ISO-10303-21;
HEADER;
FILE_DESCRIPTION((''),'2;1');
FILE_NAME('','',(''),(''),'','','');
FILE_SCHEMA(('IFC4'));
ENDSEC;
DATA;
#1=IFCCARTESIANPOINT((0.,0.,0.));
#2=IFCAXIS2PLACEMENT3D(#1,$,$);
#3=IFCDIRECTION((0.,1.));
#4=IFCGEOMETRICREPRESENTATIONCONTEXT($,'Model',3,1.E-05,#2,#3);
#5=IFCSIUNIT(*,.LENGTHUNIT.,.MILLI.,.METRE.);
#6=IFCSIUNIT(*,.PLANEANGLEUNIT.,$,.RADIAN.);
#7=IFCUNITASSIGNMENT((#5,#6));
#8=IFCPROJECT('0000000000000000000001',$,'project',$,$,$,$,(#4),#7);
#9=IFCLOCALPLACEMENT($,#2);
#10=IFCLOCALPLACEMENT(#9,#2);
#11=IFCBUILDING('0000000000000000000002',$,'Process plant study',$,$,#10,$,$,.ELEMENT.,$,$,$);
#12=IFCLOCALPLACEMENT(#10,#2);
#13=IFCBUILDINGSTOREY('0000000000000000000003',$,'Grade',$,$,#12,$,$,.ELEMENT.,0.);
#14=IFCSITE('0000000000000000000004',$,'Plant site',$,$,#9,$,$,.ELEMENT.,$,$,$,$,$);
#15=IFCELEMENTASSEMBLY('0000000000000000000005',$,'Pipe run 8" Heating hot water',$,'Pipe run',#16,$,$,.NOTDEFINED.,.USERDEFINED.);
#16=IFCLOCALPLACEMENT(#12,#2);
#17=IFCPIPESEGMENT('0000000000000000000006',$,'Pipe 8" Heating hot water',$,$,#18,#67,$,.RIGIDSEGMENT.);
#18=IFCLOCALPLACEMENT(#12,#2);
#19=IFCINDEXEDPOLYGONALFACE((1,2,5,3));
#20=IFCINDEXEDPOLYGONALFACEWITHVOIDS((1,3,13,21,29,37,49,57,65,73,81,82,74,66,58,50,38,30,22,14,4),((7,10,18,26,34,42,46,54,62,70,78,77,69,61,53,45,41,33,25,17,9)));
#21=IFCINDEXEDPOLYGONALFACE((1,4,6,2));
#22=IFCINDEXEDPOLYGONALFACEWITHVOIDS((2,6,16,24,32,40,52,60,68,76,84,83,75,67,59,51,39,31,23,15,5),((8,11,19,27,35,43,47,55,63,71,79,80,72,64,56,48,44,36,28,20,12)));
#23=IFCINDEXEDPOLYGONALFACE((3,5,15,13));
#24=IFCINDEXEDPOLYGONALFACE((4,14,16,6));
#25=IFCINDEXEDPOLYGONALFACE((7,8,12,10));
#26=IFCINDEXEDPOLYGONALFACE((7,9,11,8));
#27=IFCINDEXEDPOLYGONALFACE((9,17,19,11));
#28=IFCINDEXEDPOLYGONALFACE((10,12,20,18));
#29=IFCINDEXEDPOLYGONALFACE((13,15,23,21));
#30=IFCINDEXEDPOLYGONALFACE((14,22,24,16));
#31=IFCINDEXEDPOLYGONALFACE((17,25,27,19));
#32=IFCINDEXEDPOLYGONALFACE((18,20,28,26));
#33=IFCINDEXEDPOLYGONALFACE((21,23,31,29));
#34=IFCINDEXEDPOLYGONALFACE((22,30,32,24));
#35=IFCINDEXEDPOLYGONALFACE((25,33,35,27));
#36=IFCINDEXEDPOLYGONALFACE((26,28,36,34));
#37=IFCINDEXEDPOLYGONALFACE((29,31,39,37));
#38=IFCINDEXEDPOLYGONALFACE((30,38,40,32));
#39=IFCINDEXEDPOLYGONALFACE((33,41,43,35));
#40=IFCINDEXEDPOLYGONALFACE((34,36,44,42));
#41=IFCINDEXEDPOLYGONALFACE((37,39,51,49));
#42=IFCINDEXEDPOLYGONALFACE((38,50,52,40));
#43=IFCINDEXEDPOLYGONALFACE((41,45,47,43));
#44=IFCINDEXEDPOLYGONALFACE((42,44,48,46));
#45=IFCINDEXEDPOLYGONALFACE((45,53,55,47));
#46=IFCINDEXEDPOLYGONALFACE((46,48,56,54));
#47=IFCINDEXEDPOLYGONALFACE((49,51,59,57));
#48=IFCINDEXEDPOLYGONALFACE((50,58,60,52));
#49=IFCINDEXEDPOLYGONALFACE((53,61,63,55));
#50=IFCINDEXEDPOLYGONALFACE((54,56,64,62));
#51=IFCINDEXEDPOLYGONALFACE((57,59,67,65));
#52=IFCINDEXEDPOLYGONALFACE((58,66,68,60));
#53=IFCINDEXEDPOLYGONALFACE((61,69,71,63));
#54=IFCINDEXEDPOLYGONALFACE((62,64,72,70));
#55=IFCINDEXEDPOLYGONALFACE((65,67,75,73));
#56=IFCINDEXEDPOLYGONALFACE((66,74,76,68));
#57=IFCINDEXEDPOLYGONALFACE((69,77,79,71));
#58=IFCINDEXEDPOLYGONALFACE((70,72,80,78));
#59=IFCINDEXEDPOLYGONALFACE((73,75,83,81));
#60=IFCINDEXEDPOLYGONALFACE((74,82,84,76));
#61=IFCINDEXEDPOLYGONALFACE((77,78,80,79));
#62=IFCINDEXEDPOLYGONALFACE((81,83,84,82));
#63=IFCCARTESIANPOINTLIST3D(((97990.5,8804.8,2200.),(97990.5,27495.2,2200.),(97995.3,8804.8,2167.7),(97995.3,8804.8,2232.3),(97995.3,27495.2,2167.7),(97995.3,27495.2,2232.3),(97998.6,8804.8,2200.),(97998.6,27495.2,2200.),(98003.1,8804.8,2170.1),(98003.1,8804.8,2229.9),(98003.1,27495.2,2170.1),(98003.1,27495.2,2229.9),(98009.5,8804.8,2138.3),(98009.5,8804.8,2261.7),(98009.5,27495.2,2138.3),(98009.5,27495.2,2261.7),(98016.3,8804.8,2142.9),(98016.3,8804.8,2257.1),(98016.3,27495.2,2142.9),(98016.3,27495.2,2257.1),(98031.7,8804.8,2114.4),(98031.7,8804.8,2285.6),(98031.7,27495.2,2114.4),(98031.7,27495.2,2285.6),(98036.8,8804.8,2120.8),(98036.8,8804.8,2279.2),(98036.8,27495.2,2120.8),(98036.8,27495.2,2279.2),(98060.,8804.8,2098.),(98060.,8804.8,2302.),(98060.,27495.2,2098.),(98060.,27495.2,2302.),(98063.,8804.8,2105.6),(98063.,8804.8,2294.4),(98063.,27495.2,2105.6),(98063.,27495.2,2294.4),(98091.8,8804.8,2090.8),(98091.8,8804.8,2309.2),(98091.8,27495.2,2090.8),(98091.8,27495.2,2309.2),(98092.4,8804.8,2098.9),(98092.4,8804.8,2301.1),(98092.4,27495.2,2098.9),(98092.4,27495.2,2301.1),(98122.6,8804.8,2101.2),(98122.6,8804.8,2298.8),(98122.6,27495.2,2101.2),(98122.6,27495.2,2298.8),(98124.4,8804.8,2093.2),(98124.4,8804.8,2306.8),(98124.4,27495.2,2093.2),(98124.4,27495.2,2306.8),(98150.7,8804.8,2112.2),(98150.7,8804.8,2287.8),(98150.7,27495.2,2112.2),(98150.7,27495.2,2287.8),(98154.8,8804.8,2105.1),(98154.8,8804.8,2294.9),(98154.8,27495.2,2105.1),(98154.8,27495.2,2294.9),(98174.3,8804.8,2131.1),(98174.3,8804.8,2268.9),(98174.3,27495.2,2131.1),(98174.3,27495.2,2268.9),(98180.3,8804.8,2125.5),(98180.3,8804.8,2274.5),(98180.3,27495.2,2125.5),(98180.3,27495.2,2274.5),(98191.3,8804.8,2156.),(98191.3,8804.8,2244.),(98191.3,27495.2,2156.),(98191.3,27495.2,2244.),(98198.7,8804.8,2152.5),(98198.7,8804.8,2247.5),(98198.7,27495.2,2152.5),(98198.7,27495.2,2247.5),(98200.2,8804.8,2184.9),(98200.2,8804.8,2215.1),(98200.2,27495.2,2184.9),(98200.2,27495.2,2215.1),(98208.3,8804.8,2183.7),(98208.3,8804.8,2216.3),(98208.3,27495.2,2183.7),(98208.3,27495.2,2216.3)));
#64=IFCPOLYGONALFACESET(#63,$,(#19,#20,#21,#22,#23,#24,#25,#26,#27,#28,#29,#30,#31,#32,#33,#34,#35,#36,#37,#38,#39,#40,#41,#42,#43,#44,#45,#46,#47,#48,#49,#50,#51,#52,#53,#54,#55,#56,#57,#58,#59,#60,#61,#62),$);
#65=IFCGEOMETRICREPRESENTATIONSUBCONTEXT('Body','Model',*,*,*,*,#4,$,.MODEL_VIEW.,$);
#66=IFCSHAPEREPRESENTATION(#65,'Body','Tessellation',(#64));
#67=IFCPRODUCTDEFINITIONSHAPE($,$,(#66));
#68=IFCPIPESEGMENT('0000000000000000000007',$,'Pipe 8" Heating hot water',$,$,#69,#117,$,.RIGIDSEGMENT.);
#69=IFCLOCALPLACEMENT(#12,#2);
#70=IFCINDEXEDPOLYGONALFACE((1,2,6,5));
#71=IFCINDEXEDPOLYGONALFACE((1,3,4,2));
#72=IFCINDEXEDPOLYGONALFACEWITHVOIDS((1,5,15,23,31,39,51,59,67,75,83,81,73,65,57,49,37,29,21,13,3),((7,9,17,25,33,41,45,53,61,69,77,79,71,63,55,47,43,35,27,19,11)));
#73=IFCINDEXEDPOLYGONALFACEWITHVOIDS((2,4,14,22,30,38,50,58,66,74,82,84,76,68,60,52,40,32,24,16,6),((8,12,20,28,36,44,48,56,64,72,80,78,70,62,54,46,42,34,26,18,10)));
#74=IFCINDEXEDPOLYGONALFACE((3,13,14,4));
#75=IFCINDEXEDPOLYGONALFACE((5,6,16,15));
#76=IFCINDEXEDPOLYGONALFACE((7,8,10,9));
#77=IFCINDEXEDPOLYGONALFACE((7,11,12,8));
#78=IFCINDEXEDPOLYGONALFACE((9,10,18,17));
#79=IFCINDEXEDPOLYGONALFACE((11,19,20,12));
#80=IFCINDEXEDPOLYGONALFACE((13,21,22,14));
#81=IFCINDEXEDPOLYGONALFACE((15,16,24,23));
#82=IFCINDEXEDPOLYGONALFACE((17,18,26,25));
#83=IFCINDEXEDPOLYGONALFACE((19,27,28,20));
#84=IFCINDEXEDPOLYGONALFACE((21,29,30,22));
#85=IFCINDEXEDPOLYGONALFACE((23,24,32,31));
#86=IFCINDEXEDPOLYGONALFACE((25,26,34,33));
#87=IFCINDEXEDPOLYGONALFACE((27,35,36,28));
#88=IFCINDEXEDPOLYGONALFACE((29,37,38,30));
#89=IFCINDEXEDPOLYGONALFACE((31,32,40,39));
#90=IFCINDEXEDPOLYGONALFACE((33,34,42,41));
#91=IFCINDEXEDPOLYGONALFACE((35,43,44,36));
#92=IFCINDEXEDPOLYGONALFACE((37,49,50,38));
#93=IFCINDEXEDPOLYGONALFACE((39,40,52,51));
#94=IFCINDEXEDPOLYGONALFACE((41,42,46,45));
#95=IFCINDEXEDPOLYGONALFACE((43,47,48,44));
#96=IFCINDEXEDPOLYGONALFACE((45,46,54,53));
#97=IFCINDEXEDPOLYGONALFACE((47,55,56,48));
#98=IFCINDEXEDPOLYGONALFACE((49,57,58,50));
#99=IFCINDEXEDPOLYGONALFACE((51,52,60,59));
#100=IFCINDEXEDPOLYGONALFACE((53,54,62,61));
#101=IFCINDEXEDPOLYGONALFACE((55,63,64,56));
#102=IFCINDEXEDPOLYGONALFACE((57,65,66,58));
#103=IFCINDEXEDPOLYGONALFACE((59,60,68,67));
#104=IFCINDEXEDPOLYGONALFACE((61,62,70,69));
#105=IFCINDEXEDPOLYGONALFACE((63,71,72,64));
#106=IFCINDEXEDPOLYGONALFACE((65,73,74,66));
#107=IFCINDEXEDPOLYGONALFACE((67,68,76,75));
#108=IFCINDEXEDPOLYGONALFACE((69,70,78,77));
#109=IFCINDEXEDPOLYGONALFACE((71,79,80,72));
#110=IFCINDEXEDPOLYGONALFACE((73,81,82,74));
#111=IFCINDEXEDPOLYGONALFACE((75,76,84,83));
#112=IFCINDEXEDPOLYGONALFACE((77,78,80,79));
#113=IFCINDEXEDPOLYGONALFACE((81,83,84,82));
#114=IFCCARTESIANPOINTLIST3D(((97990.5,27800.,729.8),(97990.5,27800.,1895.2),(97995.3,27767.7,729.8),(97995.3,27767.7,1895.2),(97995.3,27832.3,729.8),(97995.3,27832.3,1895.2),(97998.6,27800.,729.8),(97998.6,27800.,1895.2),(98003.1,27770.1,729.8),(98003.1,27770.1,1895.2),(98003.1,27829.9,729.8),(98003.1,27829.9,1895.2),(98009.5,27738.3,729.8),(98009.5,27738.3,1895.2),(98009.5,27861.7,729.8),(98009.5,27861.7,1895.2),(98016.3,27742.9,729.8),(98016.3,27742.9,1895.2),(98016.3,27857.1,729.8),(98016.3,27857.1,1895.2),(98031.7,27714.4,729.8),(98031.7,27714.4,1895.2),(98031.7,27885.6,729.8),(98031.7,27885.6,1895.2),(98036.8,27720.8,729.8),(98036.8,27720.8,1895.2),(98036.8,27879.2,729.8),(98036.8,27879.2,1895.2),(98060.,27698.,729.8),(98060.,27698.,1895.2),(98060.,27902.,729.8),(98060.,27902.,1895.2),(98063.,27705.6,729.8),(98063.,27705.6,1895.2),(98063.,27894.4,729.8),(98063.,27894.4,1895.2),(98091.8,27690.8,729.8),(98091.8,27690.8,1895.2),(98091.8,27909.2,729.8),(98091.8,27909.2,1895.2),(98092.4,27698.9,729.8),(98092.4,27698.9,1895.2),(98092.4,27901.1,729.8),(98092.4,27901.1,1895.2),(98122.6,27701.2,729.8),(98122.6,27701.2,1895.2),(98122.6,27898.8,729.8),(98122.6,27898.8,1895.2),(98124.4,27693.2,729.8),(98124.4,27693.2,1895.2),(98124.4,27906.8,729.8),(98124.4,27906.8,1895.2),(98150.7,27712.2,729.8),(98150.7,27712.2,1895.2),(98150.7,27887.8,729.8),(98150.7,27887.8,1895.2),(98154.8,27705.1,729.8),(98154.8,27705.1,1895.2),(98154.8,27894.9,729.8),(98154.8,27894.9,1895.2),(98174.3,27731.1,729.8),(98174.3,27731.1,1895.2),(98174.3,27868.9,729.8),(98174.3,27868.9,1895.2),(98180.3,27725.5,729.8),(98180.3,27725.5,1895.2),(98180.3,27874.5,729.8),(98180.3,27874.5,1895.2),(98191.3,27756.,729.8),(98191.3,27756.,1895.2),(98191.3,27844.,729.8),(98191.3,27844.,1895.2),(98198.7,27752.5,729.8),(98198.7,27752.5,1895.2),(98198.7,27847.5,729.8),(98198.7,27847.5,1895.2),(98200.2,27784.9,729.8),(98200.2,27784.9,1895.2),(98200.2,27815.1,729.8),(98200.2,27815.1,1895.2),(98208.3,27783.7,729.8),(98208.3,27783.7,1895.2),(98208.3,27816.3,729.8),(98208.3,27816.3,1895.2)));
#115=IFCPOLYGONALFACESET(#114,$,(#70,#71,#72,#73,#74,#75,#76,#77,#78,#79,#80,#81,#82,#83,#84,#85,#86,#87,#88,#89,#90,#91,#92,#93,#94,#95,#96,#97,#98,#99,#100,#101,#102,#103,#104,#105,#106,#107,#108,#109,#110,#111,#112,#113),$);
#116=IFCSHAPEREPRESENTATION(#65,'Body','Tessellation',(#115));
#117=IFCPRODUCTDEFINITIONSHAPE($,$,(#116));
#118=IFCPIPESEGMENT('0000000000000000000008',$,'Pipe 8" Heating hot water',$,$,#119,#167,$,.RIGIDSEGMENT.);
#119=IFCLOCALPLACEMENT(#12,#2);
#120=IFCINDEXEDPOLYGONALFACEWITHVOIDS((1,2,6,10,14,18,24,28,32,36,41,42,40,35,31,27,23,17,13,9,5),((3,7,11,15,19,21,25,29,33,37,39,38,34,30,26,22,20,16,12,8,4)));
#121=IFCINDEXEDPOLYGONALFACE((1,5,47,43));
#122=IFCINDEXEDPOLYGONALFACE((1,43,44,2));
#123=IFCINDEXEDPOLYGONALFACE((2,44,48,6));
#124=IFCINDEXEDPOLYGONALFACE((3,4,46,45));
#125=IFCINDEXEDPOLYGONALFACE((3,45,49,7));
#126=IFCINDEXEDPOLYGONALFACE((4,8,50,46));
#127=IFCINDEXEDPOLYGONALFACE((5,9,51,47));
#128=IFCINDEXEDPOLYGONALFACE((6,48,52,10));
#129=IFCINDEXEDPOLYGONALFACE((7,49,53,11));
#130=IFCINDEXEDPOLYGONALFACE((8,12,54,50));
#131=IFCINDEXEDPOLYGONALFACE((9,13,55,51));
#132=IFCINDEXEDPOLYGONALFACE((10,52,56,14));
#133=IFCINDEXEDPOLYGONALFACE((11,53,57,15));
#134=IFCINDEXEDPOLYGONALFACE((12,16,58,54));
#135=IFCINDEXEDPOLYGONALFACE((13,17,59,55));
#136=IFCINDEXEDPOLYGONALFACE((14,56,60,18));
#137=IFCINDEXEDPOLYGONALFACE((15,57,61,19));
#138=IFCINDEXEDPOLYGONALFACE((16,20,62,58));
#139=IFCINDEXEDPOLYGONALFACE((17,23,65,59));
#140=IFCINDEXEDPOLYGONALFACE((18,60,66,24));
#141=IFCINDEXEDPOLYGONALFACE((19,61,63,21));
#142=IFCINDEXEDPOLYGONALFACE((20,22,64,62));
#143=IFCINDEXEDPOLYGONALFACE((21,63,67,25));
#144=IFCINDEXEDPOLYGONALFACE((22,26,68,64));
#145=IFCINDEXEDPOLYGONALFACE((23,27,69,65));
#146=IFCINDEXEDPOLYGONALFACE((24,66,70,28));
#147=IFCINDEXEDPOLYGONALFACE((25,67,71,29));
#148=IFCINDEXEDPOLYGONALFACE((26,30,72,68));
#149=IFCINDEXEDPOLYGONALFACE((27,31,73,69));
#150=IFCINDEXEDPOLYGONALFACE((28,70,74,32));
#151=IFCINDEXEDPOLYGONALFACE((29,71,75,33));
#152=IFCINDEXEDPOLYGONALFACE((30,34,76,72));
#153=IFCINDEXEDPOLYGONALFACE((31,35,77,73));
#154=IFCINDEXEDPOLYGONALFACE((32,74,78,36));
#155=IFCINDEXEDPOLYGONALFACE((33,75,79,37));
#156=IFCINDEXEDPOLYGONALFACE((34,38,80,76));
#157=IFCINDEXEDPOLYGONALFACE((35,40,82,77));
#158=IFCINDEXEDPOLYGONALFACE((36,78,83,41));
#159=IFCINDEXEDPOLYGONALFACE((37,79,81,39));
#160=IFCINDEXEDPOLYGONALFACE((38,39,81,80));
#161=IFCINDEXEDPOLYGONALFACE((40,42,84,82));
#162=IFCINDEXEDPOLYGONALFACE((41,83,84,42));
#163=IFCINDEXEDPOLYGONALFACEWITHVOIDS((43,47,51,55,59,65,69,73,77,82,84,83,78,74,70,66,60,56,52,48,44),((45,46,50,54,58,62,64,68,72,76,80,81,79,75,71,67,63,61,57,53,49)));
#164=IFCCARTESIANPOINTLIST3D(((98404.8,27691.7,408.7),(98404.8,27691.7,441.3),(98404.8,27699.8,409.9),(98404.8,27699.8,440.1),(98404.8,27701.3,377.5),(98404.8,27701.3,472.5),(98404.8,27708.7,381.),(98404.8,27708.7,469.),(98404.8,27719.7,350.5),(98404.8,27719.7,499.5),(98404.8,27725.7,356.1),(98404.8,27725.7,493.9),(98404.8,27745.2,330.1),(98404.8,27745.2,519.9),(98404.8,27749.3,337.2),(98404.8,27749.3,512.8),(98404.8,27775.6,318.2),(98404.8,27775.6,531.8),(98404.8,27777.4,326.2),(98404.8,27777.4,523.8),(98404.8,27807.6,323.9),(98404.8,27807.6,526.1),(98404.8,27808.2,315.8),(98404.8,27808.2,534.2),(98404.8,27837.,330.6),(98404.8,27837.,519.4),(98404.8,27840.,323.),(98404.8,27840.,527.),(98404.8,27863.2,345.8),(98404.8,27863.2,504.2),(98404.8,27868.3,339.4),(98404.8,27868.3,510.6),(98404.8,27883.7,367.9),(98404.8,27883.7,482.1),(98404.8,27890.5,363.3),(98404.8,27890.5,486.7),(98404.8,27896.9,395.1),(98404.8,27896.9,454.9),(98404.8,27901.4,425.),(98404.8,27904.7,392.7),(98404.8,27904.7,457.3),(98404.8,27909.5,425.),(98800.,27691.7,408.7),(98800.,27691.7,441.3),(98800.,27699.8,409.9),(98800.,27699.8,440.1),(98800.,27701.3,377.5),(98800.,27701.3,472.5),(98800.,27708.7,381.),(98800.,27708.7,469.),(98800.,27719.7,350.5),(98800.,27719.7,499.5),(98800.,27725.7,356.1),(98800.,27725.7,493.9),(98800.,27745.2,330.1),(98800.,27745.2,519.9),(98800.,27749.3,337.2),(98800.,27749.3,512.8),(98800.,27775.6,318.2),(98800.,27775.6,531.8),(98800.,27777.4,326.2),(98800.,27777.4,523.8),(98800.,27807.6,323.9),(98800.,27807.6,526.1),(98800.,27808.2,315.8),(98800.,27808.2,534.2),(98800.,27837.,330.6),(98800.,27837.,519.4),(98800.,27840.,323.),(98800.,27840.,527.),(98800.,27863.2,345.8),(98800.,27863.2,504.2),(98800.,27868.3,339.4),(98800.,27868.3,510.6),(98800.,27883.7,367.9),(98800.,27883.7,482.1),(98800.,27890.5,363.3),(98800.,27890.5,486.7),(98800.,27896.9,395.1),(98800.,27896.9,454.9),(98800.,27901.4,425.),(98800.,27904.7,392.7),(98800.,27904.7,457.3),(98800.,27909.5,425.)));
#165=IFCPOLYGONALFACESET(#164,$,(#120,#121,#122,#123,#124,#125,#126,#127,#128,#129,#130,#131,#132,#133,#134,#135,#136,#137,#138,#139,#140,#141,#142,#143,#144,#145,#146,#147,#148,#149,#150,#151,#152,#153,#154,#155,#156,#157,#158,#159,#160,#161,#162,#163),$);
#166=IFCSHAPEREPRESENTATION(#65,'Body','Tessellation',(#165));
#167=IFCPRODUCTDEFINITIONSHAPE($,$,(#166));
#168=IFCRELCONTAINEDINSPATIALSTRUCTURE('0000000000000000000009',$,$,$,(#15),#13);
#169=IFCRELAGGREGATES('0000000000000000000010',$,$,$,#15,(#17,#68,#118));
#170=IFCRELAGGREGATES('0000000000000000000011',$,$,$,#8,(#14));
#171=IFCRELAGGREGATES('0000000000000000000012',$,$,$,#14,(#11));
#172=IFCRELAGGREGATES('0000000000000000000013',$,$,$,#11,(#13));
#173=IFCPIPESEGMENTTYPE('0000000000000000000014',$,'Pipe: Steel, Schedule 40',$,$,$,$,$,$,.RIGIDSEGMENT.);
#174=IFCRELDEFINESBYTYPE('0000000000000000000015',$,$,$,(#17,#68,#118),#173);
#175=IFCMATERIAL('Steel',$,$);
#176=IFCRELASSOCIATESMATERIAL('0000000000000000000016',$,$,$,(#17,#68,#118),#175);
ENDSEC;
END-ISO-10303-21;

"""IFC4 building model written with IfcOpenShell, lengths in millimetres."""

from ifc_helpers import new_model, si_unit, direction, frame, origin, origin_with_axes, origin_2d, place, context, subcontext, project, spatial, hollow_circle, extrude, material, type_object, element, aggregate, save


model = new_model("IFC4")

# Units and contexts
model_context = context("Model", 3, precision=1e-05, world=origin(), true_north=direction((0.0, 1.0)))
body_context = subcontext(model_context, "Body", "Model", "MODEL_VIEW")
ifc_project = project(units=[si_unit("LENGTHUNIT", "METRE", prefix="MILLI"), si_unit("PLANEANGLEUNIT", "RADIAN")], contexts=[model_context])

# Site, building, storey
site_placement = place(None, origin())
site = spatial("IfcSite", under=ifc_project, at=site_placement, Name="Plant site", CompositionType="ELEMENT")
building_placement = place(site_placement, origin())
building = spatial("IfcBuilding", under=site, at=building_placement, Name="Process plant study", CompositionType="ELEMENT")
storey_placement = place(building_placement, origin())
storey = spatial("IfcBuildingStorey", under=building, at=storey_placement, Name="Grade", CompositionType="ELEMENT", Elevation=0.0)

# Element assembly, pipe segments
assembly_1_placement = place(storey_placement, origin_with_axes())
assembly_1 = element("IfcElementAssembly", 1, at=assembly_1_placement, inside=storey, Name="Pipe run 8\" Heating hot water", ObjectType="Pipe run", AssemblyPlace="NOTDEFINED", PredefinedType="USERDEFINED")
ifc_material = material(Name="Steel")
pipe_segment_type = type_object("IfcPipeSegmentType", Name="Pipe: Steel, Schedule 40", PredefinedType="RIGIDSEGMENT")
pipe_segment_1_placement = place(storey_placement, origin_with_axes())
pipe_segment_1 = element("IfcPipeSegment", 2, at=pipe_segment_1_placement, type_object=pipe_segment_type, material=ifc_material, Name="Pipe 8\" Heating hot water", PredefinedType="RIGIDSEGMENT", context=body_context, shape_type="SweptSolid", body=[
    extrude(hollow_circle(Radius=109.5, WallThickness=8.2, at=origin_2d()), frame((98100.0, 8804.8, 2200.0), z_axis=(0.0, 1.0, 0.0), x_axis=(-1.0, 0.0, 0.0)), (0.0, 0.0, 1.0), 18690.4),
])
pipe_segment_2_placement = place(storey_placement, origin_with_axes())
pipe_segment_2 = element("IfcPipeSegment", 3, at=pipe_segment_2_placement, type_object=pipe_segment_type, material=ifc_material, Name="Pipe 8\" Heating hot water", PredefinedType="RIGIDSEGMENT", context=body_context, shape_type="SweptSolid", body=[
    extrude(hollow_circle(Radius=109.5, WallThickness=8.2, at=origin_2d()), frame((98100.0, 27800.0, 1895.2), z_axis=(0.0, 0.0, -1.0), x_axis=(-1.0, 0.0, 0.0)), (0.0, 0.0, 1.0), 1165.4),
])
pipe_segment_3_placement = place(storey_placement, origin_with_axes())
pipe_segment_3 = element("IfcPipeSegment", 4, at=pipe_segment_3_placement, type_object=pipe_segment_type, material=ifc_material, Name="Pipe 8\" Heating hot water", PredefinedType="RIGIDSEGMENT", context=body_context, shape_type="SweptSolid", body=[
    extrude(hollow_circle(Radius=109.5, WallThickness=8.2, at=origin_2d()), frame((98404.8, 27800.0, 425.0), z_axis=(1.0, 0.0, 0.0), x_axis=(0.0, 1.0, 0.0)), (0.0, 0.0, 1.0), 395.2),
])

aggregate(assembly_1, [pipe_segment_1, pipe_segment_2, pipe_segment_3])

save(model, "model.ifc")
